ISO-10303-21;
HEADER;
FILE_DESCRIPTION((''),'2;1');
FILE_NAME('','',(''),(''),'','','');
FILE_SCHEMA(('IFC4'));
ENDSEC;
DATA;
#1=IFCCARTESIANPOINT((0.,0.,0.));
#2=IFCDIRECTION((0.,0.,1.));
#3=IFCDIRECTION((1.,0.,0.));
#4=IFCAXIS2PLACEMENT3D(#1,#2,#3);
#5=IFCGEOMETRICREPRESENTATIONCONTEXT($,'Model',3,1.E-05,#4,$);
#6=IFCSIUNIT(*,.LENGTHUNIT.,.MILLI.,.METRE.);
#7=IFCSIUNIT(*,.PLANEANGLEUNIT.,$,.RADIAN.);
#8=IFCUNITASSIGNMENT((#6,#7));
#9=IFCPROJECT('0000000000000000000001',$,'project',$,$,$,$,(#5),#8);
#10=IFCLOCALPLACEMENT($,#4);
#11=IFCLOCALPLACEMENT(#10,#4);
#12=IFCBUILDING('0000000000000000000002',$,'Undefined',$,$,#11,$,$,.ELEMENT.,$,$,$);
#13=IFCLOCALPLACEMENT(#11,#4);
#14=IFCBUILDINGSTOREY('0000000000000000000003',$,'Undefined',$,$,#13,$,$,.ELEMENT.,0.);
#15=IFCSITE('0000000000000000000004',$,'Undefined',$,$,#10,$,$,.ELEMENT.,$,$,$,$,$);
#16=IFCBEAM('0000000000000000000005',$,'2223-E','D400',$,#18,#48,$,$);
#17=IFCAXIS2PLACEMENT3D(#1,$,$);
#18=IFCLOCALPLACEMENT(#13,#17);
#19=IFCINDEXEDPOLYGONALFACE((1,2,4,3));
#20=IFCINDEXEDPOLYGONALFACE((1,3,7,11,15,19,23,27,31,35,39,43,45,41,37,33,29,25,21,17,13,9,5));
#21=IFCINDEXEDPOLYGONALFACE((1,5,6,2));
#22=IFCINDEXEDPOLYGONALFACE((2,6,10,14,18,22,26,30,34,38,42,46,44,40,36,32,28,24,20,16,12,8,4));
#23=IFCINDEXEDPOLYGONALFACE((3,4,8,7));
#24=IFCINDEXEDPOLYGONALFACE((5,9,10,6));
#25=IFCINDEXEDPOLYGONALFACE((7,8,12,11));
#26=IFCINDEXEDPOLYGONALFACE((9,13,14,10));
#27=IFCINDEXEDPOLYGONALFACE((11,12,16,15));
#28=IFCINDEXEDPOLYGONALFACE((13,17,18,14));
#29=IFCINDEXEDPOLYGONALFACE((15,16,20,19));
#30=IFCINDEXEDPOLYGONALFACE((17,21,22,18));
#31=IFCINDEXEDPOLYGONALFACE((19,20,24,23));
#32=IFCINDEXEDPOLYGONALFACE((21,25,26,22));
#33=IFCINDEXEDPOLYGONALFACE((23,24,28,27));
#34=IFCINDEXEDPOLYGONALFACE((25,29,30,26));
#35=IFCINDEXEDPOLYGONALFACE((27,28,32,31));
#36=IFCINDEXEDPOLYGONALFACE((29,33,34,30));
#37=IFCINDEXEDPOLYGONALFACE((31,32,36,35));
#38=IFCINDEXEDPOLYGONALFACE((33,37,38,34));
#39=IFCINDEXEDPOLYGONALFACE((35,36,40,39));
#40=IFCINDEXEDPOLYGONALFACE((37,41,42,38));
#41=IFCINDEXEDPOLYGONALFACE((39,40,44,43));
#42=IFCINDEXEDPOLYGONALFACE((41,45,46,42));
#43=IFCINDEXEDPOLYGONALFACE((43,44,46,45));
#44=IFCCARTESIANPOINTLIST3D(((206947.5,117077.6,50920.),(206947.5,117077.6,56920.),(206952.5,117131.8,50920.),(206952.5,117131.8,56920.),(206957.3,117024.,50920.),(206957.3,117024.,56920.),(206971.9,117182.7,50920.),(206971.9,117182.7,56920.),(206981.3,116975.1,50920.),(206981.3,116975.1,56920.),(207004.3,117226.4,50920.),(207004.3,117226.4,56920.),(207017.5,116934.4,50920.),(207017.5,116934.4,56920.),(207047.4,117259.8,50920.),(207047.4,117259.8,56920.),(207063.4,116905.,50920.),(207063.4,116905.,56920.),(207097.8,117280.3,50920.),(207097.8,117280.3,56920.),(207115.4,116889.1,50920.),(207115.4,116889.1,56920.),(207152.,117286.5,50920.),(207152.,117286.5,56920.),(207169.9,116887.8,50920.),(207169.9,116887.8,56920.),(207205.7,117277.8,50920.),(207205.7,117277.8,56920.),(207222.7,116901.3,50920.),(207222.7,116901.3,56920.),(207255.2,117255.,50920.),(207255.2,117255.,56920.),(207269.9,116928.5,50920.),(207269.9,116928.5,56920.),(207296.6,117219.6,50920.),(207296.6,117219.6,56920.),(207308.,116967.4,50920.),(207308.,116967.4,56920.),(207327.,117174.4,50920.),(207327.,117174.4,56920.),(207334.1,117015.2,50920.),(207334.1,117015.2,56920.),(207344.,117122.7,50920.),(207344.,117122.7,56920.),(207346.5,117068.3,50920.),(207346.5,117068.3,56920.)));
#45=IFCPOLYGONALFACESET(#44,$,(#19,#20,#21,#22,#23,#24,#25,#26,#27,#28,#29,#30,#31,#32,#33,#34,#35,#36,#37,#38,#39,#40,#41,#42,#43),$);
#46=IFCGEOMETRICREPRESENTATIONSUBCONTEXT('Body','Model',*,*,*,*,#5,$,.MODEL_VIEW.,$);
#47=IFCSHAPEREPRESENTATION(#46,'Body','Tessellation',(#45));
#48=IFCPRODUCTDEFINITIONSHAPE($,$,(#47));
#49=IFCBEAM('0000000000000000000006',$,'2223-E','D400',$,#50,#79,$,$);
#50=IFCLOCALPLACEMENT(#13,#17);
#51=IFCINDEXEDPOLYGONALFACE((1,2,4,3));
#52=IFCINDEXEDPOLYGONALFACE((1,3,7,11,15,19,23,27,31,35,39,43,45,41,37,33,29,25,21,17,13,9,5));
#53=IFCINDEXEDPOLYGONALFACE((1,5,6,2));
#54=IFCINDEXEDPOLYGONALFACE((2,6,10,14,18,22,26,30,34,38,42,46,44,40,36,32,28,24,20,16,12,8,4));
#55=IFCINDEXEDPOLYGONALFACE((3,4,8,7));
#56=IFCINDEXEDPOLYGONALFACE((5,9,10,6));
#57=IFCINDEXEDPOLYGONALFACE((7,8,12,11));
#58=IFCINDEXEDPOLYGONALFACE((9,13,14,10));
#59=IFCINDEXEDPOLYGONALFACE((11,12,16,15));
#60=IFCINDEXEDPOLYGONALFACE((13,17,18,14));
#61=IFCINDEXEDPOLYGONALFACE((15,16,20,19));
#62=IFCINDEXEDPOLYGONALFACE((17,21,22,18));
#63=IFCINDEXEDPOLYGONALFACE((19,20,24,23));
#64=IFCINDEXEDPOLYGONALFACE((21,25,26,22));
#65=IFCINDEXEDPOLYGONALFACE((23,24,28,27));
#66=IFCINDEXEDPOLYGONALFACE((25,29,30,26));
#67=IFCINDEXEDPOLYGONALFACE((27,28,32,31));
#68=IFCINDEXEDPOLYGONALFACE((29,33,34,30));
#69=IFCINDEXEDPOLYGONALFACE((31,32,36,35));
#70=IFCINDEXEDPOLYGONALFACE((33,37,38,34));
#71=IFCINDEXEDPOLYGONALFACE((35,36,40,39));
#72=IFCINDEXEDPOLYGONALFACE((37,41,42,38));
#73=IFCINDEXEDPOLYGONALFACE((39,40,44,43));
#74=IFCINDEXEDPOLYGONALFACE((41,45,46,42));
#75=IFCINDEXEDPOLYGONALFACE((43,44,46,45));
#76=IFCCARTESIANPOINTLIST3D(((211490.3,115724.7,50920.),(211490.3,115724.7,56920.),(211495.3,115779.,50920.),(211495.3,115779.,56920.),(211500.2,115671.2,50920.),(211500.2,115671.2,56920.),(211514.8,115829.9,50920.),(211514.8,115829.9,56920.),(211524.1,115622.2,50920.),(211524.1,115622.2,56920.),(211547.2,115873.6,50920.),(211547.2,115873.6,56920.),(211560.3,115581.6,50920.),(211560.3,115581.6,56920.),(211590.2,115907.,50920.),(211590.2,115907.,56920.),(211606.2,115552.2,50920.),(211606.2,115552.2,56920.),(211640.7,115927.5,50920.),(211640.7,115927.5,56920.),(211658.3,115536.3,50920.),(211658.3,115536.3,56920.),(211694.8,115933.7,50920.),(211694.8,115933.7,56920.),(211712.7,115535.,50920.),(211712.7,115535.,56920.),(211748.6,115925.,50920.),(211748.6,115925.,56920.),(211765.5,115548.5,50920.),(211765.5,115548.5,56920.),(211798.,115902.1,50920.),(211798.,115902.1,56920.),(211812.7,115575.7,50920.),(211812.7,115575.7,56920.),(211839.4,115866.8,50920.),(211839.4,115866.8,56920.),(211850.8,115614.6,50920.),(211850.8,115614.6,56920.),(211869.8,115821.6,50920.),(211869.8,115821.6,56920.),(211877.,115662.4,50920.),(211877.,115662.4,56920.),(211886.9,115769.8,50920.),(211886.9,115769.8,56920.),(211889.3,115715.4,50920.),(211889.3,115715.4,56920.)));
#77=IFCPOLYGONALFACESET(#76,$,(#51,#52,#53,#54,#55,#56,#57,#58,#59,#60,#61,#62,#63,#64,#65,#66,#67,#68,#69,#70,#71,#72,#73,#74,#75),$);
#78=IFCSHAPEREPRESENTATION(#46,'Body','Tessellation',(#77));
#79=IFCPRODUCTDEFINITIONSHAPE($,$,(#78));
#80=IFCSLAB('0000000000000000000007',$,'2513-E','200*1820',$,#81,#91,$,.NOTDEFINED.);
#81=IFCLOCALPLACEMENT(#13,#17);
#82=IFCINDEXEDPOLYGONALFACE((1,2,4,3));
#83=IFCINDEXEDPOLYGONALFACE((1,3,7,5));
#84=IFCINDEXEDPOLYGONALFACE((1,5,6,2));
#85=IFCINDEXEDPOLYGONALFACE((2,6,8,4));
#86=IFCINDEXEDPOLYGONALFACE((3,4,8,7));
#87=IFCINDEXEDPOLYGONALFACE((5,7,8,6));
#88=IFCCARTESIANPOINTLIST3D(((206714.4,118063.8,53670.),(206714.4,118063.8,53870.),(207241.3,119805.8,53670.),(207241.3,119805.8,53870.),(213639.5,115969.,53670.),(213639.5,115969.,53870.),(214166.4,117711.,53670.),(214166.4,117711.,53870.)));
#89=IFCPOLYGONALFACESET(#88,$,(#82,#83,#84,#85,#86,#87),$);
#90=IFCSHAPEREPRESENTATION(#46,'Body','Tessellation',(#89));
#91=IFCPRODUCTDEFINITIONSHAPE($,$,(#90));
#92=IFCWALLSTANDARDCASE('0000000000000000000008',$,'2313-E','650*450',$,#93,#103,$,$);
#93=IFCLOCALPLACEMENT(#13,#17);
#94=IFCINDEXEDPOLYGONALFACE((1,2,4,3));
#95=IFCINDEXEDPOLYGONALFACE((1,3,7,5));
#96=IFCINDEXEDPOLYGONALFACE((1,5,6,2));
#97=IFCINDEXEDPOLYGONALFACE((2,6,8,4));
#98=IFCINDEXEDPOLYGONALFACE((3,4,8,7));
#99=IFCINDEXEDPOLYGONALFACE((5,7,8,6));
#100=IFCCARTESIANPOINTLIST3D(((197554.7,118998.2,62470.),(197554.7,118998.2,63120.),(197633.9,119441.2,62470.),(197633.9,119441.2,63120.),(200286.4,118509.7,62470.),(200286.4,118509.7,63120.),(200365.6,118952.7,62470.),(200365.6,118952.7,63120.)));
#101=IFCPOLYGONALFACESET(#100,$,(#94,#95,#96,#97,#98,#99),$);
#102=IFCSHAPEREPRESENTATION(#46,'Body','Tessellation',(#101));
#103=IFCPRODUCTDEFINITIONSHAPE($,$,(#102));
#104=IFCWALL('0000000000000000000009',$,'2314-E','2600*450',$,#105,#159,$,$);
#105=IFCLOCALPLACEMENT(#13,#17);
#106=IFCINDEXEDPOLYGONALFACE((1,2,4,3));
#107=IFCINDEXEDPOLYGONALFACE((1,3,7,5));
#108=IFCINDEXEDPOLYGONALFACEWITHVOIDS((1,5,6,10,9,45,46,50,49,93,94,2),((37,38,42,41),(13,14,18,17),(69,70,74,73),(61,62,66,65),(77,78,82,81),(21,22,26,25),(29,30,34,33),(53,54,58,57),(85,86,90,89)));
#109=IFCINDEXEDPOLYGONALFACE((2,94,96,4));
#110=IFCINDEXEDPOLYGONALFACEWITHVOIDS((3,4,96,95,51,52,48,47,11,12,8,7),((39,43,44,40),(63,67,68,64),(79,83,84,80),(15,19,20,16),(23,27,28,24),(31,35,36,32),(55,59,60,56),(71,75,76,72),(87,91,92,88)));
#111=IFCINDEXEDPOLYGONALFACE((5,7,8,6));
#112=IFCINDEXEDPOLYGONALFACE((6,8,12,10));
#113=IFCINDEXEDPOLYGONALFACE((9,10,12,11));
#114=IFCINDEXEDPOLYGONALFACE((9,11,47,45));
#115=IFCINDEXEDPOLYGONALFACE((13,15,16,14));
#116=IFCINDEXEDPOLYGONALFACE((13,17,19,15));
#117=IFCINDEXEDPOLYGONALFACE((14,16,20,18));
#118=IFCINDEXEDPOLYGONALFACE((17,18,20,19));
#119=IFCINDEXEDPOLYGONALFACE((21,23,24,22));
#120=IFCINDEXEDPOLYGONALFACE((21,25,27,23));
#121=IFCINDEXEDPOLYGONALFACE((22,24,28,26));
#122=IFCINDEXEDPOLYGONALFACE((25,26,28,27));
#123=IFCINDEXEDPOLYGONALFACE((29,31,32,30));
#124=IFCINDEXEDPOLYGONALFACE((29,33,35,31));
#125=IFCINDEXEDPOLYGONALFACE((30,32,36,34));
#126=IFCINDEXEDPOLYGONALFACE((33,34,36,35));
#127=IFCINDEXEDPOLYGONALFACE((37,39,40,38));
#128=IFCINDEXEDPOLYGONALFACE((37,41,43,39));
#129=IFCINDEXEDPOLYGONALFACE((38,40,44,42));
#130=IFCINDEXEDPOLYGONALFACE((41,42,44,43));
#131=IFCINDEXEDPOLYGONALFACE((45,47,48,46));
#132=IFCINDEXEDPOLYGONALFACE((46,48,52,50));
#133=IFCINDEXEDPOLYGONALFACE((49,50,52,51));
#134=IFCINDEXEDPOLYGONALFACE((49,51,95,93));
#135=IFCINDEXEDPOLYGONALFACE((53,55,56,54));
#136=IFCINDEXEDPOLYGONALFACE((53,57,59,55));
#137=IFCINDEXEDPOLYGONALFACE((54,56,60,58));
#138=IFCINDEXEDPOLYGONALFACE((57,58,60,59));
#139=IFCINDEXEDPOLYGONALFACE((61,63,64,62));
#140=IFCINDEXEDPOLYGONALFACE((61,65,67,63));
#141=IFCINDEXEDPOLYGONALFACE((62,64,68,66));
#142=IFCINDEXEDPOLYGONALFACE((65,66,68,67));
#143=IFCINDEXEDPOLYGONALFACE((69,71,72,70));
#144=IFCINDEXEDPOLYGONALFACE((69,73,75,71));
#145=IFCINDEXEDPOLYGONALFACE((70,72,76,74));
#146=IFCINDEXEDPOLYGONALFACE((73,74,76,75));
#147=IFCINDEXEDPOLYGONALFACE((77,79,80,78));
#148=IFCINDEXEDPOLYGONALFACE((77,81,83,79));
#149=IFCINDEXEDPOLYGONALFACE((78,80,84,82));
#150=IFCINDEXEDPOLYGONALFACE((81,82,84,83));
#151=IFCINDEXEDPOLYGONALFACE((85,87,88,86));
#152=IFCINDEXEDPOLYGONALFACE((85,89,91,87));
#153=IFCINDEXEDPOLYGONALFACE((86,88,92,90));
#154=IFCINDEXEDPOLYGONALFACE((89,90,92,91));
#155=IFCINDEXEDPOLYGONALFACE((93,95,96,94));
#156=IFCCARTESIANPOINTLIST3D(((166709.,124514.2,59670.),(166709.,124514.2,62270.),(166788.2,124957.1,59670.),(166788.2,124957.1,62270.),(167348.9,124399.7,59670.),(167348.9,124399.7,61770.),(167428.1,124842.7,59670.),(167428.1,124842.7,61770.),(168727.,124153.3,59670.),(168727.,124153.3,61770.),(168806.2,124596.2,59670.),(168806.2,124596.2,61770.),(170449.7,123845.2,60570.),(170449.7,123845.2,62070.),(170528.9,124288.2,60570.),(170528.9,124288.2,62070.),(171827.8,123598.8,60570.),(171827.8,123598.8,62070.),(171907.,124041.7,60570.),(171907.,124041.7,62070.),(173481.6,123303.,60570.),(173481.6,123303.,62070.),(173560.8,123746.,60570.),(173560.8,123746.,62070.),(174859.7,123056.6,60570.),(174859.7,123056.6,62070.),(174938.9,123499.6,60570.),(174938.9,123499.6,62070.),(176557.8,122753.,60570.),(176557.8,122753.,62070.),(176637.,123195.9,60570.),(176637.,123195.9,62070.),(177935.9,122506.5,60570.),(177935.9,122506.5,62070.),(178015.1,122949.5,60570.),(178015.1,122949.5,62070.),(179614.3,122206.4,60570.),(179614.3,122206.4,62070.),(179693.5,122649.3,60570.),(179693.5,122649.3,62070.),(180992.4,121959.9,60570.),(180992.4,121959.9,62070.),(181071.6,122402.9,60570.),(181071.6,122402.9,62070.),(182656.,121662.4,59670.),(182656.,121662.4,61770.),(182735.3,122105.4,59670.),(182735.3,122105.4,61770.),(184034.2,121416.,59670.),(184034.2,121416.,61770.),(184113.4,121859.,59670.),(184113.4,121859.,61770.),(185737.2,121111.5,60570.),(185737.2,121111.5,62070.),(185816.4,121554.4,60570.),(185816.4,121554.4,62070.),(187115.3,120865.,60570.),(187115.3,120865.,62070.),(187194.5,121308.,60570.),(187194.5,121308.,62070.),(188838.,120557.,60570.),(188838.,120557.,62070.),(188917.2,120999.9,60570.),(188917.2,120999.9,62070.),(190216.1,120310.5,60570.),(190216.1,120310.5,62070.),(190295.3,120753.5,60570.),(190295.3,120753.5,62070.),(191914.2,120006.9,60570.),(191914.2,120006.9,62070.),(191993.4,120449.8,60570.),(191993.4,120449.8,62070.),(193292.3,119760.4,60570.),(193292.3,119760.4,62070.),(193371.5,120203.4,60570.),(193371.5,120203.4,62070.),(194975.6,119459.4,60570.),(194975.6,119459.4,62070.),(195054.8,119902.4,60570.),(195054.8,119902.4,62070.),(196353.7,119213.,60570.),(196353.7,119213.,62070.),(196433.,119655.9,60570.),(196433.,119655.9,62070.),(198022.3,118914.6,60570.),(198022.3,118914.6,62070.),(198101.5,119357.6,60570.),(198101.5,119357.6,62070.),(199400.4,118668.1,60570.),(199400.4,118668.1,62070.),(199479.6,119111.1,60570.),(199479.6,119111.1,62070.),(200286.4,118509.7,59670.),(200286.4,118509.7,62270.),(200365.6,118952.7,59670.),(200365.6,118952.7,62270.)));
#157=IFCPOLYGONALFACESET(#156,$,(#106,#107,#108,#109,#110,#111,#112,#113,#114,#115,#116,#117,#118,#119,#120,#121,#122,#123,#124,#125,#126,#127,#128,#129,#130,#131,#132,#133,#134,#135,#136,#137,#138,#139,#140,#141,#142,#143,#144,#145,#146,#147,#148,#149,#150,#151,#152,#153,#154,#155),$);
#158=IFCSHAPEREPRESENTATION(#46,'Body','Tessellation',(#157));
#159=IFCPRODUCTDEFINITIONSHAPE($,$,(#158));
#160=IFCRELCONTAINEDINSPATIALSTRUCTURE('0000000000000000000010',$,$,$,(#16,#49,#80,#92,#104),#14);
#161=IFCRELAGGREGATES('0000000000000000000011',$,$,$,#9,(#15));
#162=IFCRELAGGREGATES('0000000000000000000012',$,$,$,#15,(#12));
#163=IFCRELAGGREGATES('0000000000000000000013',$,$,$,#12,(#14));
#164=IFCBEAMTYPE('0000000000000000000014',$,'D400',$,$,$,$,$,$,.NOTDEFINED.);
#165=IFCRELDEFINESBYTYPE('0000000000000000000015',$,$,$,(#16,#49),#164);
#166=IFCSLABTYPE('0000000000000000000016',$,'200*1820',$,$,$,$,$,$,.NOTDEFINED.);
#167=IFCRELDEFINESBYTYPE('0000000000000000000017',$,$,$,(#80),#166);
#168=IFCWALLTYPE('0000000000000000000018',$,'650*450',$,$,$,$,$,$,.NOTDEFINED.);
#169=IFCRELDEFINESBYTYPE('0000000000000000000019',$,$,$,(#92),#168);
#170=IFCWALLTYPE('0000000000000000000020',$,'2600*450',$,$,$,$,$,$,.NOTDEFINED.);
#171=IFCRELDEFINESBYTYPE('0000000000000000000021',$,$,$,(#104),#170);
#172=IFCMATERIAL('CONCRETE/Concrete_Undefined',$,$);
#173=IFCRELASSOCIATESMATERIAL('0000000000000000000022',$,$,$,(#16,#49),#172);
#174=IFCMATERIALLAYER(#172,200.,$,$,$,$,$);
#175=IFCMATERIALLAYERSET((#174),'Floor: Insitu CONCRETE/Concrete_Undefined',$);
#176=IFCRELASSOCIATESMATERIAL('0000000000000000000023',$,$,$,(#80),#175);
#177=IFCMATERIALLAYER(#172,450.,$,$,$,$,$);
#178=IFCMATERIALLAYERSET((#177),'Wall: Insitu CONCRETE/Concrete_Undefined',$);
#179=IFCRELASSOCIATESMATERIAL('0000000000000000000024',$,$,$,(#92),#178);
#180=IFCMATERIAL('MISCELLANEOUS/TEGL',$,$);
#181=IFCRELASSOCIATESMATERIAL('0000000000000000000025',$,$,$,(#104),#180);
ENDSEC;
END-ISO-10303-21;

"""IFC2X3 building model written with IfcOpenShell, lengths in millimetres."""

from ifc_helpers import new_model, si_unit, frame, frame_2d, origin_with_axes, origin_2d_with_axis, place, context, subcontext, project, spatial, polyline, rectangle, circle, outline, extrude, boolean, material, layer, layer_set, layer_usage, type_object, element, save


model = new_model("IFC2X3")

# Units and contexts
model_context = context("Model", 3, precision=1e-05, world=origin_with_axes())
body_context = subcontext(model_context, "Body", "Model", "MODEL_VIEW")
ifc_project = project(units=[si_unit("LENGTHUNIT", "METRE", prefix="MILLI"), si_unit("PLANEANGLEUNIT", "RADIAN")], contexts=[model_context])

# Site, building, storey
site_placement = place(None, origin_with_axes())
site = spatial("IfcSite", under=ifc_project, at=site_placement, Name="Undefined", CompositionType="ELEMENT")
building_placement = place(site_placement, origin_with_axes())
building = spatial("IfcBuilding", under=site, at=building_placement, Name="Undefined", CompositionType="ELEMENT")
storey_placement = place(building_placement, origin_with_axes())
storey = spatial("IfcBuildingStorey", under=building, at=storey_placement, Name="Undefined", CompositionType="ELEMENT", Elevation=0.0)

# Beams
ifc_material_1 = material(Name="CONCRETE/Concrete_Undefined")
beam_type_1 = type_object("IfcBeamType", Name="D400", PredefinedType="NOTDEFINED")
for number, where, z_axis, x_axis, name in (
    (1, (207147.3, 117086.6, 50920.0), (0.999728, -0.023321, 0.0), (0.0, 0.0, 1.0), "2223-E"),
    (2, (211690.1, 115733.7, 50920.0), (0.999728, -0.023321, 0.0), (0.0, 0.0, 1.0), "2223-E"),
):
    element("IfcBeam", number, at=place(storey_placement, frame(where, z_axis=z_axis, x_axis=x_axis)), inside=storey, type_object=beam_type_1, material=ifc_material_1, Name=name, Description="D400", context=body_context, shape_type="SweptSolid", body=[
        extrude(circle(Radius=200.0, at=origin_2d_with_axis()), frame((6000.0, 0.0, 0.0), z_axis=(-1.0, 0.0, 0.0), x_axis=(0.0, -1.0, 0.0)), (0.0, 0.0, 1.0), 6000.0),
    ])

# Slab
ifc_layer_1 = layer(ifc_material_1, 200.0)
ifc_layer_set_1 = layer_set([ifc_layer_1], Name="Floor: Insitu CONCRETE/Concrete_Undefined")
ifc_layer_usage_1 = layer_usage(ifc_layer_set_1, "AXIS3", "POSITIVE", -100.0)
slab_type = type_object("IfcSlabType", Name="200*1820", PredefinedType="NOTDEFINED")
slab_placement = place(storey_placement, frame((206714.4, 118063.8, 53770.0), z_axis=(0.0, 0.0, 1.0), x_axis=(0.957167, -0.289538, 0.0)))
element("IfcSlab", 3, at=slab_placement, inside=storey, type_object=slab_type, material=ifc_layer_usage_1, Name="2513-E", Description="200*1820", PredefinedType="NOTDEFINED", context=body_context, shape_type="SweptSolid", body=[
    extrude(outline(polyline([(0.0, 0.0), (7235.0, 0.0), (7235.0, 1820.0), (0.0, 1820.0), (0.0, 0.0)])), frame((0.0, 0.0, -100.0), z_axis=(0.0, 0.0, 1.0), x_axis=(1.0, 0.0, 0.0)), (0.0, 0.0, 1.0), 200.0),
])

# Walls
ifc_layer_2 = layer(ifc_material_1, 450.0)
ifc_layer_set_2 = layer_set([ifc_layer_2], Name="Wall: Insitu CONCRETE/Concrete_Undefined")
ifc_layer_usage_2 = layer_usage(ifc_layer_set_2, "AXIS2", "POSITIVE", -225.0)
wall_type_1 = type_object("IfcWallType", Name="650*450", PredefinedType="NOTDEFINED")
wall_1_placement = place(storey_placement, frame((200326.0, 118731.2, 62470.0), z_axis=(0.0, 0.0, 1.0), x_axis=(-0.984384, 0.176035, 0.0)))
element("IfcWallStandardCase", 4, at=wall_1_placement, inside=storey, type_object=wall_type_1, material=ifc_layer_usage_2, Name="2313-E", Description="650*450", context=body_context, shape_type="SweptSolid", body=[
    extrude(rectangle(XDim=2775.0, YDim=450.0, at=frame_2d((0.0, 1387.5), x_axis=(0.0, -1.0))), frame((0.0, 0.0, 0.0), z_axis=(0.0, 0.0, 1.0), x_axis=(0.0, -1.0, 0.0)), (0.0, 0.0, 1.0), 650.0),
])
ifc_material_2 = material(Name="MISCELLANEOUS/TEGL")
wall_type_2 = type_object("IfcWallType", Name="2600*450", PredefinedType="NOTDEFINED")
wall_2_placement = place(storey_placement, frame((200326.0, 118731.2, 59670.0), z_axis=(0.0, 0.0, 1.0), x_axis=(-0.984385, 0.176032, 0.0)))
solid_1 = boolean("DIFFERENCE", boolean("DIFFERENCE", boolean("DIFFERENCE", boolean("DIFFERENCE", boolean("DIFFERENCE", boolean("DIFFERENCE", boolean("DIFFERENCE", boolean("DIFFERENCE", extrude(rectangle(XDim=34110.0, YDim=450.0, at=frame_2d((0.0, 17055.0), x_axis=(0.0, -1.0))), frame((0.0, 0.0, 0.0), z_axis=(0.0, 0.0, 1.0), x_axis=(0.0, -1.0, 0.0)), (0.0, 0.0, 1.0), 2600.0), extrude(rectangle(XDim=1400.0, YDim=450.0, at=frame_2d((0.0, 700.0), x_axis=(0.0, -1.0))), frame((33460.0, 0.0, 0.0), z_axis=(0.0, 0.0, 1.0), x_axis=(0.0, 1.0, 0.0)), (0.0, 0.0, 1.0), 2100.0)), extrude(rectangle(XDim=1400.0, YDim=450.0, at=frame_2d((0.0, 700.0), x_axis=(0.0, -1.0))), frame((30310.0, 0.0, 900.0), z_axis=(0.0, 0.0, 1.0), x_axis=(0.0, 1.0, 0.0)), (0.0, 0.0, 1.0), 1500.0)), extrude(rectangle(XDim=1400.0, YDim=450.0, at=frame_2d((0.0, 700.0), x_axis=(0.0, -1.0))), frame((27230.0, 0.0, 900.0), z_axis=(0.0, 0.0, 1.0), x_axis=(0.0, 1.0, 0.0)), (0.0, 0.0, 1.0), 1500.0)), extrude(rectangle(XDim=1400.0, YDim=450.0, at=frame_2d((0.0, 700.0), x_axis=(0.0, -1.0))), frame((24105.0, 0.0, 900.0), z_axis=(0.0, 0.0, 1.0), x_axis=(0.0, 1.0, 0.0)), (0.0, 0.0, 1.0), 1500.0)), extrude(rectangle(XDim=1400.0, YDim=450.0, at=frame_2d((0.0, 700.0), x_axis=(0.0, -1.0))), frame((17910.0, 0.0, 0.0), z_axis=(0.0, 0.0, 1.0), x_axis=(0.0, 1.0, 0.0)), (0.0, 0.0, 1.0), 2100.0)), extrude(rectangle(XDim=1400.0, YDim=450.0, at=frame_2d((0.0, 700.0), x_axis=(0.0, -1.0))), frame((14780.0, 0.0, 900.0), z_axis=(0.0, 0.0, 1.0), x_axis=(0.0, 1.0, 0.0)), (0.0, 0.0, 1.0), 1500.0)), extrude(rectangle(XDim=1400.0, YDim=450.0, at=frame_2d((0.0, 700.0), x_axis=(0.0, -1.0))), frame((11630.0, 0.0, 900.0), z_axis=(0.0, 0.0, 1.0), x_axis=(0.0, 1.0, 0.0)), (0.0, 0.0, 1.0), 1500.0)), extrude(rectangle(XDim=1400.0, YDim=450.0, at=frame_2d((0.0, 700.0), x_axis=(0.0, -1.0))), frame((8505.0, 0.0, 900.0), z_axis=(0.0, 0.0, 1.0), x_axis=(0.0, 1.0, 0.0)), (0.0, 0.0, 1.0), 1500.0))
element("IfcWall", 5, at=wall_2_placement, inside=storey, type_object=wall_type_2, material=ifc_material_2, Name="2314-E", Description="2600*450", context=body_context, shape_type="CSG", body=[
    boolean("DIFFERENCE", boolean("DIFFERENCE", boolean("DIFFERENCE", solid_1, extrude(rectangle(XDim=1400.0, YDim=450.0, at=frame_2d((0.0, 700.0), x_axis=(0.0, -1.0))), frame((5395.0, 0.0, 900.0), z_axis=(0.0, 0.0, 1.0), x_axis=(0.0, 1.0, 0.0)), (0.0, 0.0, 1.0), 1500.0)), extrude(rectangle(XDim=1400.0, YDim=450.0, at=frame_2d((0.0, 700.0), x_axis=(0.0, -1.0))), frame((2300.0, 0.0, 900.0), z_axis=(0.0, 0.0, 1.0), x_axis=(0.0, 1.0, 0.0)), (0.0, 0.0, 1.0), 1500.0)), extrude(rectangle(XDim=1400.0, YDim=450.0, at=frame_2d((0.0, 700.0), x_axis=(0.0, -1.0))), frame((21000.0, 0.0, 900.0), z_axis=(0.0, 0.0, 1.0), x_axis=(0.0, 1.0, 0.0)), (0.0, 0.0, 1.0), 1500.0)),
])

save(model, "model.ifc")
